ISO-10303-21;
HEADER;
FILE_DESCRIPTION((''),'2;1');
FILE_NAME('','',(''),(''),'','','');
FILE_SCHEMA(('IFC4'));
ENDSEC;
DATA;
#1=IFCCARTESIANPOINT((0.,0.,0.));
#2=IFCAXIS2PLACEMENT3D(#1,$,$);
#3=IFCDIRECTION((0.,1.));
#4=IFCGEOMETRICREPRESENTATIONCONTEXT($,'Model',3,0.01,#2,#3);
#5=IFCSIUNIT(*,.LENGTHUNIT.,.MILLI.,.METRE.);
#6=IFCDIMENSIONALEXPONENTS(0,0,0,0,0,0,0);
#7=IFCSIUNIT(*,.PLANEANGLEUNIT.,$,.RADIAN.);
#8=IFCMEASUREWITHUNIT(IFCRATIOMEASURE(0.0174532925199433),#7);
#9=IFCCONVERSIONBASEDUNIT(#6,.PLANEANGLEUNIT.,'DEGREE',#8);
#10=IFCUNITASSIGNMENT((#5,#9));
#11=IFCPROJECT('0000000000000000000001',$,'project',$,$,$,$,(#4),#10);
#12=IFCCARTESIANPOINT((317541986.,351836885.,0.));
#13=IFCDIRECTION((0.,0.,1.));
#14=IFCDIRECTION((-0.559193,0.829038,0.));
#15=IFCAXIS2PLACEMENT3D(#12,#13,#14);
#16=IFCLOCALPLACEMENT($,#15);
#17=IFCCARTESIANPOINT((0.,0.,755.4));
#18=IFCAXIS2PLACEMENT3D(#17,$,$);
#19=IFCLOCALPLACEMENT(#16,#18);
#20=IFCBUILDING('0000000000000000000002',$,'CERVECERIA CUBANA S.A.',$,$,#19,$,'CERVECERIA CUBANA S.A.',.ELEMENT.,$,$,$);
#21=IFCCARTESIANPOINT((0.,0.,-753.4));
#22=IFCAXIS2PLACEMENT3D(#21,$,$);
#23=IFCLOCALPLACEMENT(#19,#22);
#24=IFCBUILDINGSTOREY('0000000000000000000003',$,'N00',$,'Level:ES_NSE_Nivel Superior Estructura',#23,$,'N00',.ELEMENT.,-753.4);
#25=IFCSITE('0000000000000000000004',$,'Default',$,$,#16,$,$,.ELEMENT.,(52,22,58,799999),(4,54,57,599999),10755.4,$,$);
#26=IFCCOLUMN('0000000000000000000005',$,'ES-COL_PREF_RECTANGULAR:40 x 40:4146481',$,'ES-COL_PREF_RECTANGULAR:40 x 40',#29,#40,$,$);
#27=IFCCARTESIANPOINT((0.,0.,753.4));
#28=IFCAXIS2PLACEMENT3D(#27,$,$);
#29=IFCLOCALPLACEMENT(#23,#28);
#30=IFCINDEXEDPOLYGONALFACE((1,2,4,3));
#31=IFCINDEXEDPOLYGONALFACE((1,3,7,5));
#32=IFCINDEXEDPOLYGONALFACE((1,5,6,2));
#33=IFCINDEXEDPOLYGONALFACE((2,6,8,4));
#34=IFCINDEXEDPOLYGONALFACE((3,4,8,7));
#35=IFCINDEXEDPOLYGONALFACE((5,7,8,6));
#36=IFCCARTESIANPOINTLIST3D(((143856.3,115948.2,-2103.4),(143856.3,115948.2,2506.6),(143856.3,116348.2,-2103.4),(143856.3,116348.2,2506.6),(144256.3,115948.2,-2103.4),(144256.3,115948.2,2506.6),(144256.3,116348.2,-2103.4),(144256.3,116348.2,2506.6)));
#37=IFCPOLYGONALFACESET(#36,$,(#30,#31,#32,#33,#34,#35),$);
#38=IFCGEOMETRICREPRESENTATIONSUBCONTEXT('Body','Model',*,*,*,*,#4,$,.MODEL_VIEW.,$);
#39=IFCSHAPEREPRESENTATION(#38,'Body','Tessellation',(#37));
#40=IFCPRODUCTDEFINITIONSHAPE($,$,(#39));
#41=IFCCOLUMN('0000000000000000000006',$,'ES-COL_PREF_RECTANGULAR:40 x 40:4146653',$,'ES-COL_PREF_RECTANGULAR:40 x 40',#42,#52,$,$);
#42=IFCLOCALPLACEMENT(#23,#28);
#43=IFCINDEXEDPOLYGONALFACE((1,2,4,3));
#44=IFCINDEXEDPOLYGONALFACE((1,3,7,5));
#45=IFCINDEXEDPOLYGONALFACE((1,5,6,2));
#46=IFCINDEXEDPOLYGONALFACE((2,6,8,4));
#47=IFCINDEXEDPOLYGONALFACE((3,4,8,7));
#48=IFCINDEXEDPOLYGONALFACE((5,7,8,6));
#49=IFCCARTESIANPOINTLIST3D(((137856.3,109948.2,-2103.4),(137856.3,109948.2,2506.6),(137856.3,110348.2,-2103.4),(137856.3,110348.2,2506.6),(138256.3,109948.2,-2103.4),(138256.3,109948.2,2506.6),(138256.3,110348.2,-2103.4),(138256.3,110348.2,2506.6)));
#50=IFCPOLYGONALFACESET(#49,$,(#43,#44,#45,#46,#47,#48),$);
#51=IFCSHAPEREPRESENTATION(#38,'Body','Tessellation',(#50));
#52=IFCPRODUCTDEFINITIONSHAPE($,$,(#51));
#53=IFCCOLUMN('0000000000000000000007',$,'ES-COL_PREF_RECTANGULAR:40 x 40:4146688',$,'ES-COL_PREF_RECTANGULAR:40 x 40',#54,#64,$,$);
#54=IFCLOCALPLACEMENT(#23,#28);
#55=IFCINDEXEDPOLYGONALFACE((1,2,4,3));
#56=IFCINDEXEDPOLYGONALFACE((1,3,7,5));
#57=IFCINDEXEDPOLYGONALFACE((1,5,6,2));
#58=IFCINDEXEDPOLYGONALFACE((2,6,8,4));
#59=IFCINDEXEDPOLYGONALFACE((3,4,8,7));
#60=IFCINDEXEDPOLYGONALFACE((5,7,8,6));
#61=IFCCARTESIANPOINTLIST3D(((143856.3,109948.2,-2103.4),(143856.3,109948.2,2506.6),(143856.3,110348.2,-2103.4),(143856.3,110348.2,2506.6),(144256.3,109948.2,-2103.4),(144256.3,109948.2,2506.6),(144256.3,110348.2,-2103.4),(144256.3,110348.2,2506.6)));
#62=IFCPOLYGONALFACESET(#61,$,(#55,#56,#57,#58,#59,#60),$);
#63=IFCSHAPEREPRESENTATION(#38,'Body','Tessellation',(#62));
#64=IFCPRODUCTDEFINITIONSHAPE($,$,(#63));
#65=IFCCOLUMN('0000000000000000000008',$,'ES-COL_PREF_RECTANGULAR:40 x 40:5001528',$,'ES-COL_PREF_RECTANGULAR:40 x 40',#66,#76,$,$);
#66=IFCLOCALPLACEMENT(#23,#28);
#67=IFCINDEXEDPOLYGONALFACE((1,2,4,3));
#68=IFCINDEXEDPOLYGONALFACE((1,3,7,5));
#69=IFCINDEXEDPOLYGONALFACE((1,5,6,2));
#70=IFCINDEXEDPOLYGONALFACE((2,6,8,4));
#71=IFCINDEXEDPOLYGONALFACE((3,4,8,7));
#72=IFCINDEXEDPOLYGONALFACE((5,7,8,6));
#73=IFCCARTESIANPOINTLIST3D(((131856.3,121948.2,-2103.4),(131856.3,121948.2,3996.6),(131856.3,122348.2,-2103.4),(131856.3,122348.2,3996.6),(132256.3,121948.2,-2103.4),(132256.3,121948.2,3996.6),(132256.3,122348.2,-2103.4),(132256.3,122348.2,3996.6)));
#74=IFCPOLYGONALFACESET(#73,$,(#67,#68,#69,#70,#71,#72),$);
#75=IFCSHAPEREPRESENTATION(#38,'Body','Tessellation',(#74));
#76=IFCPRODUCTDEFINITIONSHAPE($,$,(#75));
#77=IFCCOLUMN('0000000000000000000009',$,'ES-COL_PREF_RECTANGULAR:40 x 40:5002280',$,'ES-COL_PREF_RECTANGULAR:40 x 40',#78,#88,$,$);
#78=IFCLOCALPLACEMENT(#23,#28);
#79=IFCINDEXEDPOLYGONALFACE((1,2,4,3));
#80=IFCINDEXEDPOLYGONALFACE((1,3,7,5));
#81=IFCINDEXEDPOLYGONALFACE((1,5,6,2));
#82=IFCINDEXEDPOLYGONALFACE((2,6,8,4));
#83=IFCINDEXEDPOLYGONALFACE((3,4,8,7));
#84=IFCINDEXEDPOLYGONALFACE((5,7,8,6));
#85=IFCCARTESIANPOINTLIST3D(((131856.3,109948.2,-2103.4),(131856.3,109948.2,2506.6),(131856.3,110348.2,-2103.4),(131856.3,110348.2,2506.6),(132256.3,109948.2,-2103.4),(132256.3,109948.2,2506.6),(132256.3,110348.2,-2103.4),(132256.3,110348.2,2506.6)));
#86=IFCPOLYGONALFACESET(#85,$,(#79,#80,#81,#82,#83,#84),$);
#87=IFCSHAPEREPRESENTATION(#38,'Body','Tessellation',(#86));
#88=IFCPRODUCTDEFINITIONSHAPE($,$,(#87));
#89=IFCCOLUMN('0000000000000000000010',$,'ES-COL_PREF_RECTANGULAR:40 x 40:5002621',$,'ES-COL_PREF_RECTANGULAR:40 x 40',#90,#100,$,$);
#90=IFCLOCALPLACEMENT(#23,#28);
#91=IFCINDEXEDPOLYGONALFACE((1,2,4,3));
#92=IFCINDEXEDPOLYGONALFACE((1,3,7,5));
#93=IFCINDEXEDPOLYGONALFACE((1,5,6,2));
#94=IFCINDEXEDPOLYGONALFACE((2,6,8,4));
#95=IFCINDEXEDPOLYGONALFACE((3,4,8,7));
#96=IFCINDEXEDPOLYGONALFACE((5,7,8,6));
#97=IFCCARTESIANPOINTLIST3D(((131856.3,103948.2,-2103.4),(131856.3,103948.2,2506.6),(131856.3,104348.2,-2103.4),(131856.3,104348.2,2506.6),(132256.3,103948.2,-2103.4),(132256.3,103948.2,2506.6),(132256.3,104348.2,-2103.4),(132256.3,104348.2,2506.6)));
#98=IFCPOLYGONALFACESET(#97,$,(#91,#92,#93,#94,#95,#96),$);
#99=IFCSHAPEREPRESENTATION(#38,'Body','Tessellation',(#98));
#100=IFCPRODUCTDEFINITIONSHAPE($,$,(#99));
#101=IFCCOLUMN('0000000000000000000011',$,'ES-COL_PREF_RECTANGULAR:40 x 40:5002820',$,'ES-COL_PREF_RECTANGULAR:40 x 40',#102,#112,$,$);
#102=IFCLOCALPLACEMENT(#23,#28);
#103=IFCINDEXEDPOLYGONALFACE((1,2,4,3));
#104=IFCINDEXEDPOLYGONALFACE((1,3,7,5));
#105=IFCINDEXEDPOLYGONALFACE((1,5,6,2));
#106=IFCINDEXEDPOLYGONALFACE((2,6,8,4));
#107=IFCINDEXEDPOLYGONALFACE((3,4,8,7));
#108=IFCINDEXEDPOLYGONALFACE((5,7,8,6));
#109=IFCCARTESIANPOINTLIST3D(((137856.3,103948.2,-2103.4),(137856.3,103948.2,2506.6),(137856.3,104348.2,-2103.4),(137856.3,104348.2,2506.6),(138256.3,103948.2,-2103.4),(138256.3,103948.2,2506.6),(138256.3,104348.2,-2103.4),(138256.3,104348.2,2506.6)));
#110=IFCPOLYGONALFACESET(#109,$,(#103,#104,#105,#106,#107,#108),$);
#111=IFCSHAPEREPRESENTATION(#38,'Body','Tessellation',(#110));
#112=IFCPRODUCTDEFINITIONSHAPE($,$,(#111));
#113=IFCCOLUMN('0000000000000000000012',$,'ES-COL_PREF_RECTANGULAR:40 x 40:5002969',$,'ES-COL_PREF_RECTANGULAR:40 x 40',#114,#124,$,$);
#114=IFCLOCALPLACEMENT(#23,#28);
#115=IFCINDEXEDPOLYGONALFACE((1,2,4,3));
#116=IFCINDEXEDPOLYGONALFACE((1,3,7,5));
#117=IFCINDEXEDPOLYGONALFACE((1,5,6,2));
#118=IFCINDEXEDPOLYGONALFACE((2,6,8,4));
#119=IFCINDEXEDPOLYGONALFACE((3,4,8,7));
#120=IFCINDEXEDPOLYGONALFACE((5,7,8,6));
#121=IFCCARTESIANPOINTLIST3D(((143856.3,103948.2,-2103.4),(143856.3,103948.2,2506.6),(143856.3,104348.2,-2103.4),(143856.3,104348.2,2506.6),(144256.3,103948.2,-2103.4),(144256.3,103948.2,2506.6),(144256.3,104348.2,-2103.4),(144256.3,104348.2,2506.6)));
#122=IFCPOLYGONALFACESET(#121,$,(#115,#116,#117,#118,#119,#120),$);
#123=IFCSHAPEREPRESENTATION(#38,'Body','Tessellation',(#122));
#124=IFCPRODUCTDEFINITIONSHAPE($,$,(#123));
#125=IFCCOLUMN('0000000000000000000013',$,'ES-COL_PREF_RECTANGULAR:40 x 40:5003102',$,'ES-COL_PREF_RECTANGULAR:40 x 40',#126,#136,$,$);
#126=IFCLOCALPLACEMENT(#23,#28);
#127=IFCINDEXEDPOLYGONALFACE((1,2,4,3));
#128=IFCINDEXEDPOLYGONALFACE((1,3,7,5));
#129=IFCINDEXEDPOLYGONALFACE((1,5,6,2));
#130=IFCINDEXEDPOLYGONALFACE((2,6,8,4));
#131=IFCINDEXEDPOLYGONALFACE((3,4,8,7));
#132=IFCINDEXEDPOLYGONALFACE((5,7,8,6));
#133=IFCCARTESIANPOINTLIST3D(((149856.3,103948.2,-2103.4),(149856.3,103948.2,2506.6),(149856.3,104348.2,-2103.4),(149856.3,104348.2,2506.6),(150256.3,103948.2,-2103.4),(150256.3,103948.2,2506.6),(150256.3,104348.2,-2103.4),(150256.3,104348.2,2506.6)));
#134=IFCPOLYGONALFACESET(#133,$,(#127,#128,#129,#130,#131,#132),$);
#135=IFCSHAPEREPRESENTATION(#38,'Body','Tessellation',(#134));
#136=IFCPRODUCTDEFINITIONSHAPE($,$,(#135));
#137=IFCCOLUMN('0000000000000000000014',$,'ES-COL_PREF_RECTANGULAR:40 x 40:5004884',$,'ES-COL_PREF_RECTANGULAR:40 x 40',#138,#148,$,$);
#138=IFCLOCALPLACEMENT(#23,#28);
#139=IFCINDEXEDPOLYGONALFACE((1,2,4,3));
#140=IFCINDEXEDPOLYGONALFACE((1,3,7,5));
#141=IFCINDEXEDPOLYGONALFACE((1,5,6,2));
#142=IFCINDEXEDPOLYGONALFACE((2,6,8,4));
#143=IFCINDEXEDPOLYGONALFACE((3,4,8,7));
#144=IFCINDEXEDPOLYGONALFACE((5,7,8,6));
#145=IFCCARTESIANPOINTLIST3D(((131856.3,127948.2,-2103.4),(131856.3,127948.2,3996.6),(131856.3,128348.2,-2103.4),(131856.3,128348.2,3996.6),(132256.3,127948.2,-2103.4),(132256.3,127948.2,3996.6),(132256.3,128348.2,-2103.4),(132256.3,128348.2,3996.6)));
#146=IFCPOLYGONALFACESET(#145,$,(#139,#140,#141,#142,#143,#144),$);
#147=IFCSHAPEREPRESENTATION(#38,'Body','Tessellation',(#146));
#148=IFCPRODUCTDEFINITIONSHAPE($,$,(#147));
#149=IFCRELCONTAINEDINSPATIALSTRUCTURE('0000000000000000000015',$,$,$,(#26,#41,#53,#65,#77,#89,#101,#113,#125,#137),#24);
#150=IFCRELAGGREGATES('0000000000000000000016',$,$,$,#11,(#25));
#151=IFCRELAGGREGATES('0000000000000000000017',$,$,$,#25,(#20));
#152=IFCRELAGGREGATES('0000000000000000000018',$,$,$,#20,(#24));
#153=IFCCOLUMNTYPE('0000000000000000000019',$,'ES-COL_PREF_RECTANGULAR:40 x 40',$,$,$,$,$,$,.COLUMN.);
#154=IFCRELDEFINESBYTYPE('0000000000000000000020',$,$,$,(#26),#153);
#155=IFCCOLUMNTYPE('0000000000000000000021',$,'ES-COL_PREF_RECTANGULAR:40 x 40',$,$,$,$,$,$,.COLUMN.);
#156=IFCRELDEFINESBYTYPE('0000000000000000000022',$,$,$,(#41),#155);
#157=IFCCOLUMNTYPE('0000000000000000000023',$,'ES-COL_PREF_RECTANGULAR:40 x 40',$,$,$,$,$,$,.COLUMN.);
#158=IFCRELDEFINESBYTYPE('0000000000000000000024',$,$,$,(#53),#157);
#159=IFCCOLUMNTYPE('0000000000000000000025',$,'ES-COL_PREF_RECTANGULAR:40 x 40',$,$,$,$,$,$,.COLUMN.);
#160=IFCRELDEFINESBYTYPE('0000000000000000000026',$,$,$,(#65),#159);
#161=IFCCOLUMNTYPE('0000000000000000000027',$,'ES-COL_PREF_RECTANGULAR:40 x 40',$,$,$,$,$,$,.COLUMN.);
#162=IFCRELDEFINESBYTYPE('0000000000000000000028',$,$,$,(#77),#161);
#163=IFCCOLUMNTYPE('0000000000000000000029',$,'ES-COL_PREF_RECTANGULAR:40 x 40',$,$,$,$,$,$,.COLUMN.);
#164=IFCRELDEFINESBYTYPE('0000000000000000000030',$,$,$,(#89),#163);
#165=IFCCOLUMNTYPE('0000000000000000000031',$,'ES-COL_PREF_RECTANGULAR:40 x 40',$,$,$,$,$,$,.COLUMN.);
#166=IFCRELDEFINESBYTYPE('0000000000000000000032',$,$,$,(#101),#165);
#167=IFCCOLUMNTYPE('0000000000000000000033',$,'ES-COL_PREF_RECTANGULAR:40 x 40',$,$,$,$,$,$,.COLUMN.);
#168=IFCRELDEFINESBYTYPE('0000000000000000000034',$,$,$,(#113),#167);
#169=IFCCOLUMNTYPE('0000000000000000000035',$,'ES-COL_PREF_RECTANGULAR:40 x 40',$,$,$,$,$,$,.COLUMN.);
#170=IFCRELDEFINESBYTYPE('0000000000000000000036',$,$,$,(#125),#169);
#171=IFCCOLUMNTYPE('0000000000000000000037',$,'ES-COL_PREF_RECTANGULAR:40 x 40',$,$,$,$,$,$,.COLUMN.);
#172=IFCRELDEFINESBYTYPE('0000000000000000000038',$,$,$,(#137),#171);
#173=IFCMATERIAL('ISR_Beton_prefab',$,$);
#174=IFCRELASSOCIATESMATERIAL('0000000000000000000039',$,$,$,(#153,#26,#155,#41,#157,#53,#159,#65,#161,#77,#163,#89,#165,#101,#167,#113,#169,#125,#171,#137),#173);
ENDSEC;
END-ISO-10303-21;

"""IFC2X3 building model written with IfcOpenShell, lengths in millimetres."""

from ifc_helpers import new_model, entity, si_unit, converted_unit, direction, frame, frame_2d, origin, origin_2d_with_axis, place, context, subcontext, project, spatial, rectangle, extrude, source, transform, mapped, material, type_object, type_shapes, element, save


model = new_model("IFC2X3")

# Units and contexts
model_context = context("Model", 3, precision=0.01, world=origin(), true_north=direction((0.0, 1.0)))
body_context = subcontext(model_context, "Body", "Model", "MODEL_VIEW")
ifc_project = project(units=[si_unit("LENGTHUNIT", "METRE", prefix="MILLI"), converted_unit("PLANEANGLEUNIT", "DEGREE", entity("IfcRatioMeasure", 0.0174532925199433), si_unit("PLANEANGLEUNIT", "RADIAN"), dimensions=[0, 0, 0, 0, 0, 0, 0])], contexts=[model_context])

# Site, building, storey
site_placement = place(None, frame((317541986.0, 351836885.0, 0.0), z_axis=(0.0, 0.0, 1.0), x_axis=(-0.559193, 0.829038, 0.0)))
site = spatial("IfcSite", under=ifc_project, at=site_placement, Name="Default", CompositionType="ELEMENT", RefLatitude=(52, 22, 58, 799999), RefLongitude=(4, 54, 57, 599999), RefElevation=10755.4)
building_placement = place(site_placement, frame((0.0, 0.0, 755.4)))
building = spatial("IfcBuilding", under=site, at=building_placement, Name="CERVECERIA CUBANA S.A.", LongName="CERVECERIA CUBANA S.A.", CompositionType="ELEMENT")
storey_placement = place(building_placement, frame((0.0, 0.0, -753.4)))
storey = spatial("IfcBuildingStorey", under=building, at=storey_placement, Name="N00", ObjectType="Level:ES_NSE_Nivel Superior Estructura", LongName="N00", CompositionType="ELEMENT", Elevation=-753.4)

# Columns
ifc_material_1 = material(Name="ISR_Beton_prefab")
column_type_1 = type_object("IfcColumnType", Name="ES-COL_PREF_RECTANGULAR:40 x 40", PredefinedType="COLUMN", material=ifc_material_1)
shared_shape_1 = source(origin(), body_context, "Body", "SweptSolid", [
    extrude(rectangle(XDim=400.0, YDim=400.0, at=frame_2d((0.0, 0.0), x_axis=(1.0, 0.0))), frame((144056.3, 116148.2, -2103.4), z_axis=(0.0, 0.0, 1.0), x_axis=(0.0, -1.0, 0.0)), (0.0, 0.0, 1.0), 4610.0),
])
type_shapes(column_type_1, [shared_shape_1])
column_1_placement = place(storey_placement, frame((0.0, 0.0, 753.4)))
element("IfcColumn", 1, at=column_1_placement, inside=storey, type_object=column_type_1, material=ifc_material_1, Name="ES-COL_PREF_RECTANGULAR:40 x 40:4146481", ObjectType="ES-COL_PREF_RECTANGULAR:40 x 40", context=body_context, shape_type="MappedRepresentation", body=[
    mapped(shared_shape_1, transform((0.0, 0.0, 0.0), scale=1.0)),
])
column_type_2 = type_object("IfcColumnType", Name="ES-COL_PREF_RECTANGULAR:40 x 40", PredefinedType="COLUMN", material=ifc_material_1)
shared_shape_2 = source(origin(), body_context, "Body", "SweptSolid", [
    extrude(rectangle(XDim=400.0, YDim=400.0, at=origin_2d_with_axis()), frame((138056.3, 110148.2, -2103.4), z_axis=(0.0, 0.0, 1.0), x_axis=(0.0, -1.0, 0.0)), (0.0, 0.0, 1.0), 4610.0),
])
type_shapes(column_type_2, [shared_shape_2])
column_2_placement = place(storey_placement, frame((0.0, 0.0, 753.4)))
element("IfcColumn", 2, at=column_2_placement, inside=storey, type_object=column_type_2, material=ifc_material_1, Name="ES-COL_PREF_RECTANGULAR:40 x 40:4146653", ObjectType="ES-COL_PREF_RECTANGULAR:40 x 40", context=body_context, shape_type="MappedRepresentation", body=[
    mapped(shared_shape_2, transform((0.0, 0.0, 0.0), scale=1.0)),
])
column_type_3 = type_object("IfcColumnType", Name="ES-COL_PREF_RECTANGULAR:40 x 40", PredefinedType="COLUMN", material=ifc_material_1)
shared_shape_3 = source(origin(), body_context, "Body", "SweptSolid", [
    extrude(rectangle(XDim=400.0, YDim=400.0, at=frame_2d((0.0, 0.0), x_axis=(1.0, 0.0))), frame((144056.3, 110148.2, -2103.4), z_axis=(0.0, 0.0, 1.0), x_axis=(0.0, -1.0, 0.0)), (0.0, 0.0, 1.0), 4610.0),
])
type_shapes(column_type_3, [shared_shape_3])
column_3_placement = place(storey_placement, frame((0.0, 0.0, 753.4)))
element("IfcColumn", 3, at=column_3_placement, inside=storey, type_object=column_type_3, material=ifc_material_1, Name="ES-COL_PREF_RECTANGULAR:40 x 40:4146688", ObjectType="ES-COL_PREF_RECTANGULAR:40 x 40", context=body_context, shape_type="MappedRepresentation", body=[
    mapped(shared_shape_3, transform((0.0, 0.0, 0.0), scale=1.0)),
])
column_type_4 = type_object("IfcColumnType", Name="ES-COL_PREF_RECTANGULAR:40 x 40", PredefinedType="COLUMN", material=ifc_material_1)
shared_shape_4 = source(origin(), body_context, "Body", "SweptSolid", [
    extrude(rectangle(XDim=400.0, YDim=400.0, at=origin_2d_with_axis()), frame((132056.3, 122148.2, -2103.4), z_axis=(0.0, 0.0, 1.0), x_axis=(0.0, -1.0, 0.0)), (0.0, 0.0, 1.0), 6100.0),
])
type_shapes(column_type_4, [shared_shape_4])
column_4_placement = place(storey_placement, frame((0.0, 0.0, 753.4)))
element("IfcColumn", 4, at=column_4_placement, inside=storey, type_object=column_type_4, material=ifc_material_1, Name="ES-COL_PREF_RECTANGULAR:40 x 40:5001528", ObjectType="ES-COL_PREF_RECTANGULAR:40 x 40", context=body_context, shape_type="MappedRepresentation", body=[
    mapped(shared_shape_4, transform((0.0, 0.0, 0.0), scale=1.0)),
])
column_type_5 = type_object("IfcColumnType", Name="ES-COL_PREF_RECTANGULAR:40 x 40", PredefinedType="COLUMN", material=ifc_material_1)
shared_shape_5 = source(origin(), body_context, "Body", "SweptSolid", [
    extrude(rectangle(XDim=400.0, YDim=400.0, at=frame_2d((0.0, 0.0), x_axis=(1.0, 0.0))), frame((132056.3, 110148.2, -2103.4), z_axis=(0.0, 0.0, 1.0), x_axis=(0.0, -1.0, 0.0)), (0.0, 0.0, 1.0), 4610.0),
])
type_shapes(column_type_5, [shared_shape_5])
column_5_placement = place(storey_placement, frame((0.0, 0.0, 753.4)))
element("IfcColumn", 5, at=column_5_placement, inside=storey, type_object=column_type_5, material=ifc_material_1, Name="ES-COL_PREF_RECTANGULAR:40 x 40:5002280", ObjectType="ES-COL_PREF_RECTANGULAR:40 x 40", context=body_context, shape_type="MappedRepresentation", body=[
    mapped(shared_shape_5, transform((0.0, 0.0, 0.0), scale=1.0)),
])
column_type_6 = type_object("IfcColumnType", Name="ES-COL_PREF_RECTANGULAR:40 x 40", PredefinedType="COLUMN", material=ifc_material_1)
shared_shape_6 = source(origin(), body_context, "Body", "SweptSolid", [
    extrude(rectangle(XDim=400.0, YDim=400.0, at=frame_2d((0.0, 0.0), x_axis=(1.0, 0.0))), frame((132056.3, 104148.2, -2103.4), z_axis=(0.0, 0.0, 1.0), x_axis=(0.0, -1.0, 0.0)), (0.0, 0.0, 1.0), 4610.0),
])
type_shapes(column_type_6, [shared_shape_6])
column_6_placement = place(storey_placement, frame((0.0, 0.0, 753.4)))
element("IfcColumn", 6, at=column_6_placement, inside=storey, type_object=column_type_6, material=ifc_material_1, Name="ES-COL_PREF_RECTANGULAR:40 x 40:5002621", ObjectType="ES-COL_PREF_RECTANGULAR:40 x 40", context=body_context, shape_type="MappedRepresentation", body=[
    mapped(shared_shape_6, transform((0.0, 0.0, 0.0), scale=1.0)),
])
column_type_7 = type_object("IfcColumnType", Name="ES-COL_PREF_RECTANGULAR:40 x 40", PredefinedType="COLUMN", material=ifc_material_1)
shared_shape_7 = source(origin(), body_context, "Body", "SweptSolid", [
    extrude(rectangle(XDim=400.0, YDim=400.0, at=frame_2d((0.0, 0.0), x_axis=(1.0, 0.0))), frame((138056.3, 104148.2, -2103.4), z_axis=(0.0, 0.0, 1.0), x_axis=(0.0, -1.0, 0.0)), (0.0, 0.0, 1.0), 4610.0),
])
type_shapes(column_type_7, [shared_shape_7])
column_7_placement = place(storey_placement, frame((0.0, 0.0, 753.4)))
element("IfcColumn", 7, at=column_7_placement, inside=storey, type_object=column_type_7, material=ifc_material_1, Name="ES-COL_PREF_RECTANGULAR:40 x 40:5002820", ObjectType="ES-COL_PREF_RECTANGULAR:40 x 40", context=body_context, shape_type="MappedRepresentation", body=[
    mapped(shared_shape_7, transform((0.0, 0.0, 0.0), scale=1.0)),
])
column_type_8 = type_object("IfcColumnType", Name="ES-COL_PREF_RECTANGULAR:40 x 40", PredefinedType="COLUMN", material=ifc_material_1)
shared_shape_8 = source(origin(), body_context, "Body", "SweptSolid", [
    extrude(rectangle(XDim=400.0, YDim=400.0, at=frame_2d((0.0, 0.0), x_axis=(1.0, 0.0))), frame((144056.3, 104148.2, -2103.4), z_axis=(0.0, 0.0, 1.0), x_axis=(0.0, -1.0, 0.0)), (0.0, 0.0, 1.0), 4610.0),
])
type_shapes(column_type_8, [shared_shape_8])
column_8_placement = place(storey_placement, frame((0.0, 0.0, 753.4)))
element("IfcColumn", 8, at=column_8_placement, inside=storey, type_object=column_type_8, material=ifc_material_1, Name="ES-COL_PREF_RECTANGULAR:40 x 40:5002969", ObjectType="ES-COL_PREF_RECTANGULAR:40 x 40", context=body_context, shape_type="MappedRepresentation", body=[
    mapped(shared_shape_8, transform((0.0, 0.0, 0.0), scale=1.0)),
])
column_type_9 = type_object("IfcColumnType", Name="ES-COL_PREF_RECTANGULAR:40 x 40", PredefinedType="COLUMN", material=ifc_material_1)
shared_shape_9 = source(origin(), body_context, "Body", "SweptSolid", [
    extrude(rectangle(XDim=400.0, YDim=400.0, at=origin_2d_with_axis()), frame((150056.3, 104148.2, -2103.4), z_axis=(0.0, 0.0, 1.0), x_axis=(0.0, -1.0, 0.0)), (0.0, 0.0, 1.0), 4610.0),
])
type_shapes(column_type_9, [shared_shape_9])
column_9_placement = place(storey_placement, frame((0.0, 0.0, 753.4)))
element("IfcColumn", 9, at=column_9_placement, inside=storey, type_object=column_type_9, material=ifc_material_1, Name="ES-COL_PREF_RECTANGULAR:40 x 40:5003102", ObjectType="ES-COL_PREF_RECTANGULAR:40 x 40", context=body_context, shape_type="MappedRepresentation", body=[
    mapped(shared_shape_9, transform((0.0, 0.0, 0.0), scale=1.0)),
])
column_type_10 = type_object("IfcColumnType", Name="ES-COL_PREF_RECTANGULAR:40 x 40", PredefinedType="COLUMN", material=ifc_material_1)
shared_shape_10 = source(origin(), body_context, "Body", "SweptSolid", [
    extrude(rectangle(XDim=400.0, YDim=400.0, at=origin_2d_with_axis()), frame((132056.3, 128148.2, -2103.4), z_axis=(0.0, 0.0, 1.0), x_axis=(0.0, -1.0, 0.0)), (0.0, 0.0, 1.0), 6100.0),
])
type_shapes(column_type_10, [shared_shape_10])
column_10_placement = place(storey_placement, frame((0.0, 0.0, 753.4)))
element("IfcColumn", 10, at=column_10_placement, inside=storey, type_object=column_type_10, material=ifc_material_1, Name="ES-COL_PREF_RECTANGULAR:40 x 40:5004884", ObjectType="ES-COL_PREF_RECTANGULAR:40 x 40", context=body_context, shape_type="MappedRepresentation", body=[
    mapped(shared_shape_10, transform((0.0, 0.0, 0.0), scale=1.0)),
])

save(model, "model.ifc")
